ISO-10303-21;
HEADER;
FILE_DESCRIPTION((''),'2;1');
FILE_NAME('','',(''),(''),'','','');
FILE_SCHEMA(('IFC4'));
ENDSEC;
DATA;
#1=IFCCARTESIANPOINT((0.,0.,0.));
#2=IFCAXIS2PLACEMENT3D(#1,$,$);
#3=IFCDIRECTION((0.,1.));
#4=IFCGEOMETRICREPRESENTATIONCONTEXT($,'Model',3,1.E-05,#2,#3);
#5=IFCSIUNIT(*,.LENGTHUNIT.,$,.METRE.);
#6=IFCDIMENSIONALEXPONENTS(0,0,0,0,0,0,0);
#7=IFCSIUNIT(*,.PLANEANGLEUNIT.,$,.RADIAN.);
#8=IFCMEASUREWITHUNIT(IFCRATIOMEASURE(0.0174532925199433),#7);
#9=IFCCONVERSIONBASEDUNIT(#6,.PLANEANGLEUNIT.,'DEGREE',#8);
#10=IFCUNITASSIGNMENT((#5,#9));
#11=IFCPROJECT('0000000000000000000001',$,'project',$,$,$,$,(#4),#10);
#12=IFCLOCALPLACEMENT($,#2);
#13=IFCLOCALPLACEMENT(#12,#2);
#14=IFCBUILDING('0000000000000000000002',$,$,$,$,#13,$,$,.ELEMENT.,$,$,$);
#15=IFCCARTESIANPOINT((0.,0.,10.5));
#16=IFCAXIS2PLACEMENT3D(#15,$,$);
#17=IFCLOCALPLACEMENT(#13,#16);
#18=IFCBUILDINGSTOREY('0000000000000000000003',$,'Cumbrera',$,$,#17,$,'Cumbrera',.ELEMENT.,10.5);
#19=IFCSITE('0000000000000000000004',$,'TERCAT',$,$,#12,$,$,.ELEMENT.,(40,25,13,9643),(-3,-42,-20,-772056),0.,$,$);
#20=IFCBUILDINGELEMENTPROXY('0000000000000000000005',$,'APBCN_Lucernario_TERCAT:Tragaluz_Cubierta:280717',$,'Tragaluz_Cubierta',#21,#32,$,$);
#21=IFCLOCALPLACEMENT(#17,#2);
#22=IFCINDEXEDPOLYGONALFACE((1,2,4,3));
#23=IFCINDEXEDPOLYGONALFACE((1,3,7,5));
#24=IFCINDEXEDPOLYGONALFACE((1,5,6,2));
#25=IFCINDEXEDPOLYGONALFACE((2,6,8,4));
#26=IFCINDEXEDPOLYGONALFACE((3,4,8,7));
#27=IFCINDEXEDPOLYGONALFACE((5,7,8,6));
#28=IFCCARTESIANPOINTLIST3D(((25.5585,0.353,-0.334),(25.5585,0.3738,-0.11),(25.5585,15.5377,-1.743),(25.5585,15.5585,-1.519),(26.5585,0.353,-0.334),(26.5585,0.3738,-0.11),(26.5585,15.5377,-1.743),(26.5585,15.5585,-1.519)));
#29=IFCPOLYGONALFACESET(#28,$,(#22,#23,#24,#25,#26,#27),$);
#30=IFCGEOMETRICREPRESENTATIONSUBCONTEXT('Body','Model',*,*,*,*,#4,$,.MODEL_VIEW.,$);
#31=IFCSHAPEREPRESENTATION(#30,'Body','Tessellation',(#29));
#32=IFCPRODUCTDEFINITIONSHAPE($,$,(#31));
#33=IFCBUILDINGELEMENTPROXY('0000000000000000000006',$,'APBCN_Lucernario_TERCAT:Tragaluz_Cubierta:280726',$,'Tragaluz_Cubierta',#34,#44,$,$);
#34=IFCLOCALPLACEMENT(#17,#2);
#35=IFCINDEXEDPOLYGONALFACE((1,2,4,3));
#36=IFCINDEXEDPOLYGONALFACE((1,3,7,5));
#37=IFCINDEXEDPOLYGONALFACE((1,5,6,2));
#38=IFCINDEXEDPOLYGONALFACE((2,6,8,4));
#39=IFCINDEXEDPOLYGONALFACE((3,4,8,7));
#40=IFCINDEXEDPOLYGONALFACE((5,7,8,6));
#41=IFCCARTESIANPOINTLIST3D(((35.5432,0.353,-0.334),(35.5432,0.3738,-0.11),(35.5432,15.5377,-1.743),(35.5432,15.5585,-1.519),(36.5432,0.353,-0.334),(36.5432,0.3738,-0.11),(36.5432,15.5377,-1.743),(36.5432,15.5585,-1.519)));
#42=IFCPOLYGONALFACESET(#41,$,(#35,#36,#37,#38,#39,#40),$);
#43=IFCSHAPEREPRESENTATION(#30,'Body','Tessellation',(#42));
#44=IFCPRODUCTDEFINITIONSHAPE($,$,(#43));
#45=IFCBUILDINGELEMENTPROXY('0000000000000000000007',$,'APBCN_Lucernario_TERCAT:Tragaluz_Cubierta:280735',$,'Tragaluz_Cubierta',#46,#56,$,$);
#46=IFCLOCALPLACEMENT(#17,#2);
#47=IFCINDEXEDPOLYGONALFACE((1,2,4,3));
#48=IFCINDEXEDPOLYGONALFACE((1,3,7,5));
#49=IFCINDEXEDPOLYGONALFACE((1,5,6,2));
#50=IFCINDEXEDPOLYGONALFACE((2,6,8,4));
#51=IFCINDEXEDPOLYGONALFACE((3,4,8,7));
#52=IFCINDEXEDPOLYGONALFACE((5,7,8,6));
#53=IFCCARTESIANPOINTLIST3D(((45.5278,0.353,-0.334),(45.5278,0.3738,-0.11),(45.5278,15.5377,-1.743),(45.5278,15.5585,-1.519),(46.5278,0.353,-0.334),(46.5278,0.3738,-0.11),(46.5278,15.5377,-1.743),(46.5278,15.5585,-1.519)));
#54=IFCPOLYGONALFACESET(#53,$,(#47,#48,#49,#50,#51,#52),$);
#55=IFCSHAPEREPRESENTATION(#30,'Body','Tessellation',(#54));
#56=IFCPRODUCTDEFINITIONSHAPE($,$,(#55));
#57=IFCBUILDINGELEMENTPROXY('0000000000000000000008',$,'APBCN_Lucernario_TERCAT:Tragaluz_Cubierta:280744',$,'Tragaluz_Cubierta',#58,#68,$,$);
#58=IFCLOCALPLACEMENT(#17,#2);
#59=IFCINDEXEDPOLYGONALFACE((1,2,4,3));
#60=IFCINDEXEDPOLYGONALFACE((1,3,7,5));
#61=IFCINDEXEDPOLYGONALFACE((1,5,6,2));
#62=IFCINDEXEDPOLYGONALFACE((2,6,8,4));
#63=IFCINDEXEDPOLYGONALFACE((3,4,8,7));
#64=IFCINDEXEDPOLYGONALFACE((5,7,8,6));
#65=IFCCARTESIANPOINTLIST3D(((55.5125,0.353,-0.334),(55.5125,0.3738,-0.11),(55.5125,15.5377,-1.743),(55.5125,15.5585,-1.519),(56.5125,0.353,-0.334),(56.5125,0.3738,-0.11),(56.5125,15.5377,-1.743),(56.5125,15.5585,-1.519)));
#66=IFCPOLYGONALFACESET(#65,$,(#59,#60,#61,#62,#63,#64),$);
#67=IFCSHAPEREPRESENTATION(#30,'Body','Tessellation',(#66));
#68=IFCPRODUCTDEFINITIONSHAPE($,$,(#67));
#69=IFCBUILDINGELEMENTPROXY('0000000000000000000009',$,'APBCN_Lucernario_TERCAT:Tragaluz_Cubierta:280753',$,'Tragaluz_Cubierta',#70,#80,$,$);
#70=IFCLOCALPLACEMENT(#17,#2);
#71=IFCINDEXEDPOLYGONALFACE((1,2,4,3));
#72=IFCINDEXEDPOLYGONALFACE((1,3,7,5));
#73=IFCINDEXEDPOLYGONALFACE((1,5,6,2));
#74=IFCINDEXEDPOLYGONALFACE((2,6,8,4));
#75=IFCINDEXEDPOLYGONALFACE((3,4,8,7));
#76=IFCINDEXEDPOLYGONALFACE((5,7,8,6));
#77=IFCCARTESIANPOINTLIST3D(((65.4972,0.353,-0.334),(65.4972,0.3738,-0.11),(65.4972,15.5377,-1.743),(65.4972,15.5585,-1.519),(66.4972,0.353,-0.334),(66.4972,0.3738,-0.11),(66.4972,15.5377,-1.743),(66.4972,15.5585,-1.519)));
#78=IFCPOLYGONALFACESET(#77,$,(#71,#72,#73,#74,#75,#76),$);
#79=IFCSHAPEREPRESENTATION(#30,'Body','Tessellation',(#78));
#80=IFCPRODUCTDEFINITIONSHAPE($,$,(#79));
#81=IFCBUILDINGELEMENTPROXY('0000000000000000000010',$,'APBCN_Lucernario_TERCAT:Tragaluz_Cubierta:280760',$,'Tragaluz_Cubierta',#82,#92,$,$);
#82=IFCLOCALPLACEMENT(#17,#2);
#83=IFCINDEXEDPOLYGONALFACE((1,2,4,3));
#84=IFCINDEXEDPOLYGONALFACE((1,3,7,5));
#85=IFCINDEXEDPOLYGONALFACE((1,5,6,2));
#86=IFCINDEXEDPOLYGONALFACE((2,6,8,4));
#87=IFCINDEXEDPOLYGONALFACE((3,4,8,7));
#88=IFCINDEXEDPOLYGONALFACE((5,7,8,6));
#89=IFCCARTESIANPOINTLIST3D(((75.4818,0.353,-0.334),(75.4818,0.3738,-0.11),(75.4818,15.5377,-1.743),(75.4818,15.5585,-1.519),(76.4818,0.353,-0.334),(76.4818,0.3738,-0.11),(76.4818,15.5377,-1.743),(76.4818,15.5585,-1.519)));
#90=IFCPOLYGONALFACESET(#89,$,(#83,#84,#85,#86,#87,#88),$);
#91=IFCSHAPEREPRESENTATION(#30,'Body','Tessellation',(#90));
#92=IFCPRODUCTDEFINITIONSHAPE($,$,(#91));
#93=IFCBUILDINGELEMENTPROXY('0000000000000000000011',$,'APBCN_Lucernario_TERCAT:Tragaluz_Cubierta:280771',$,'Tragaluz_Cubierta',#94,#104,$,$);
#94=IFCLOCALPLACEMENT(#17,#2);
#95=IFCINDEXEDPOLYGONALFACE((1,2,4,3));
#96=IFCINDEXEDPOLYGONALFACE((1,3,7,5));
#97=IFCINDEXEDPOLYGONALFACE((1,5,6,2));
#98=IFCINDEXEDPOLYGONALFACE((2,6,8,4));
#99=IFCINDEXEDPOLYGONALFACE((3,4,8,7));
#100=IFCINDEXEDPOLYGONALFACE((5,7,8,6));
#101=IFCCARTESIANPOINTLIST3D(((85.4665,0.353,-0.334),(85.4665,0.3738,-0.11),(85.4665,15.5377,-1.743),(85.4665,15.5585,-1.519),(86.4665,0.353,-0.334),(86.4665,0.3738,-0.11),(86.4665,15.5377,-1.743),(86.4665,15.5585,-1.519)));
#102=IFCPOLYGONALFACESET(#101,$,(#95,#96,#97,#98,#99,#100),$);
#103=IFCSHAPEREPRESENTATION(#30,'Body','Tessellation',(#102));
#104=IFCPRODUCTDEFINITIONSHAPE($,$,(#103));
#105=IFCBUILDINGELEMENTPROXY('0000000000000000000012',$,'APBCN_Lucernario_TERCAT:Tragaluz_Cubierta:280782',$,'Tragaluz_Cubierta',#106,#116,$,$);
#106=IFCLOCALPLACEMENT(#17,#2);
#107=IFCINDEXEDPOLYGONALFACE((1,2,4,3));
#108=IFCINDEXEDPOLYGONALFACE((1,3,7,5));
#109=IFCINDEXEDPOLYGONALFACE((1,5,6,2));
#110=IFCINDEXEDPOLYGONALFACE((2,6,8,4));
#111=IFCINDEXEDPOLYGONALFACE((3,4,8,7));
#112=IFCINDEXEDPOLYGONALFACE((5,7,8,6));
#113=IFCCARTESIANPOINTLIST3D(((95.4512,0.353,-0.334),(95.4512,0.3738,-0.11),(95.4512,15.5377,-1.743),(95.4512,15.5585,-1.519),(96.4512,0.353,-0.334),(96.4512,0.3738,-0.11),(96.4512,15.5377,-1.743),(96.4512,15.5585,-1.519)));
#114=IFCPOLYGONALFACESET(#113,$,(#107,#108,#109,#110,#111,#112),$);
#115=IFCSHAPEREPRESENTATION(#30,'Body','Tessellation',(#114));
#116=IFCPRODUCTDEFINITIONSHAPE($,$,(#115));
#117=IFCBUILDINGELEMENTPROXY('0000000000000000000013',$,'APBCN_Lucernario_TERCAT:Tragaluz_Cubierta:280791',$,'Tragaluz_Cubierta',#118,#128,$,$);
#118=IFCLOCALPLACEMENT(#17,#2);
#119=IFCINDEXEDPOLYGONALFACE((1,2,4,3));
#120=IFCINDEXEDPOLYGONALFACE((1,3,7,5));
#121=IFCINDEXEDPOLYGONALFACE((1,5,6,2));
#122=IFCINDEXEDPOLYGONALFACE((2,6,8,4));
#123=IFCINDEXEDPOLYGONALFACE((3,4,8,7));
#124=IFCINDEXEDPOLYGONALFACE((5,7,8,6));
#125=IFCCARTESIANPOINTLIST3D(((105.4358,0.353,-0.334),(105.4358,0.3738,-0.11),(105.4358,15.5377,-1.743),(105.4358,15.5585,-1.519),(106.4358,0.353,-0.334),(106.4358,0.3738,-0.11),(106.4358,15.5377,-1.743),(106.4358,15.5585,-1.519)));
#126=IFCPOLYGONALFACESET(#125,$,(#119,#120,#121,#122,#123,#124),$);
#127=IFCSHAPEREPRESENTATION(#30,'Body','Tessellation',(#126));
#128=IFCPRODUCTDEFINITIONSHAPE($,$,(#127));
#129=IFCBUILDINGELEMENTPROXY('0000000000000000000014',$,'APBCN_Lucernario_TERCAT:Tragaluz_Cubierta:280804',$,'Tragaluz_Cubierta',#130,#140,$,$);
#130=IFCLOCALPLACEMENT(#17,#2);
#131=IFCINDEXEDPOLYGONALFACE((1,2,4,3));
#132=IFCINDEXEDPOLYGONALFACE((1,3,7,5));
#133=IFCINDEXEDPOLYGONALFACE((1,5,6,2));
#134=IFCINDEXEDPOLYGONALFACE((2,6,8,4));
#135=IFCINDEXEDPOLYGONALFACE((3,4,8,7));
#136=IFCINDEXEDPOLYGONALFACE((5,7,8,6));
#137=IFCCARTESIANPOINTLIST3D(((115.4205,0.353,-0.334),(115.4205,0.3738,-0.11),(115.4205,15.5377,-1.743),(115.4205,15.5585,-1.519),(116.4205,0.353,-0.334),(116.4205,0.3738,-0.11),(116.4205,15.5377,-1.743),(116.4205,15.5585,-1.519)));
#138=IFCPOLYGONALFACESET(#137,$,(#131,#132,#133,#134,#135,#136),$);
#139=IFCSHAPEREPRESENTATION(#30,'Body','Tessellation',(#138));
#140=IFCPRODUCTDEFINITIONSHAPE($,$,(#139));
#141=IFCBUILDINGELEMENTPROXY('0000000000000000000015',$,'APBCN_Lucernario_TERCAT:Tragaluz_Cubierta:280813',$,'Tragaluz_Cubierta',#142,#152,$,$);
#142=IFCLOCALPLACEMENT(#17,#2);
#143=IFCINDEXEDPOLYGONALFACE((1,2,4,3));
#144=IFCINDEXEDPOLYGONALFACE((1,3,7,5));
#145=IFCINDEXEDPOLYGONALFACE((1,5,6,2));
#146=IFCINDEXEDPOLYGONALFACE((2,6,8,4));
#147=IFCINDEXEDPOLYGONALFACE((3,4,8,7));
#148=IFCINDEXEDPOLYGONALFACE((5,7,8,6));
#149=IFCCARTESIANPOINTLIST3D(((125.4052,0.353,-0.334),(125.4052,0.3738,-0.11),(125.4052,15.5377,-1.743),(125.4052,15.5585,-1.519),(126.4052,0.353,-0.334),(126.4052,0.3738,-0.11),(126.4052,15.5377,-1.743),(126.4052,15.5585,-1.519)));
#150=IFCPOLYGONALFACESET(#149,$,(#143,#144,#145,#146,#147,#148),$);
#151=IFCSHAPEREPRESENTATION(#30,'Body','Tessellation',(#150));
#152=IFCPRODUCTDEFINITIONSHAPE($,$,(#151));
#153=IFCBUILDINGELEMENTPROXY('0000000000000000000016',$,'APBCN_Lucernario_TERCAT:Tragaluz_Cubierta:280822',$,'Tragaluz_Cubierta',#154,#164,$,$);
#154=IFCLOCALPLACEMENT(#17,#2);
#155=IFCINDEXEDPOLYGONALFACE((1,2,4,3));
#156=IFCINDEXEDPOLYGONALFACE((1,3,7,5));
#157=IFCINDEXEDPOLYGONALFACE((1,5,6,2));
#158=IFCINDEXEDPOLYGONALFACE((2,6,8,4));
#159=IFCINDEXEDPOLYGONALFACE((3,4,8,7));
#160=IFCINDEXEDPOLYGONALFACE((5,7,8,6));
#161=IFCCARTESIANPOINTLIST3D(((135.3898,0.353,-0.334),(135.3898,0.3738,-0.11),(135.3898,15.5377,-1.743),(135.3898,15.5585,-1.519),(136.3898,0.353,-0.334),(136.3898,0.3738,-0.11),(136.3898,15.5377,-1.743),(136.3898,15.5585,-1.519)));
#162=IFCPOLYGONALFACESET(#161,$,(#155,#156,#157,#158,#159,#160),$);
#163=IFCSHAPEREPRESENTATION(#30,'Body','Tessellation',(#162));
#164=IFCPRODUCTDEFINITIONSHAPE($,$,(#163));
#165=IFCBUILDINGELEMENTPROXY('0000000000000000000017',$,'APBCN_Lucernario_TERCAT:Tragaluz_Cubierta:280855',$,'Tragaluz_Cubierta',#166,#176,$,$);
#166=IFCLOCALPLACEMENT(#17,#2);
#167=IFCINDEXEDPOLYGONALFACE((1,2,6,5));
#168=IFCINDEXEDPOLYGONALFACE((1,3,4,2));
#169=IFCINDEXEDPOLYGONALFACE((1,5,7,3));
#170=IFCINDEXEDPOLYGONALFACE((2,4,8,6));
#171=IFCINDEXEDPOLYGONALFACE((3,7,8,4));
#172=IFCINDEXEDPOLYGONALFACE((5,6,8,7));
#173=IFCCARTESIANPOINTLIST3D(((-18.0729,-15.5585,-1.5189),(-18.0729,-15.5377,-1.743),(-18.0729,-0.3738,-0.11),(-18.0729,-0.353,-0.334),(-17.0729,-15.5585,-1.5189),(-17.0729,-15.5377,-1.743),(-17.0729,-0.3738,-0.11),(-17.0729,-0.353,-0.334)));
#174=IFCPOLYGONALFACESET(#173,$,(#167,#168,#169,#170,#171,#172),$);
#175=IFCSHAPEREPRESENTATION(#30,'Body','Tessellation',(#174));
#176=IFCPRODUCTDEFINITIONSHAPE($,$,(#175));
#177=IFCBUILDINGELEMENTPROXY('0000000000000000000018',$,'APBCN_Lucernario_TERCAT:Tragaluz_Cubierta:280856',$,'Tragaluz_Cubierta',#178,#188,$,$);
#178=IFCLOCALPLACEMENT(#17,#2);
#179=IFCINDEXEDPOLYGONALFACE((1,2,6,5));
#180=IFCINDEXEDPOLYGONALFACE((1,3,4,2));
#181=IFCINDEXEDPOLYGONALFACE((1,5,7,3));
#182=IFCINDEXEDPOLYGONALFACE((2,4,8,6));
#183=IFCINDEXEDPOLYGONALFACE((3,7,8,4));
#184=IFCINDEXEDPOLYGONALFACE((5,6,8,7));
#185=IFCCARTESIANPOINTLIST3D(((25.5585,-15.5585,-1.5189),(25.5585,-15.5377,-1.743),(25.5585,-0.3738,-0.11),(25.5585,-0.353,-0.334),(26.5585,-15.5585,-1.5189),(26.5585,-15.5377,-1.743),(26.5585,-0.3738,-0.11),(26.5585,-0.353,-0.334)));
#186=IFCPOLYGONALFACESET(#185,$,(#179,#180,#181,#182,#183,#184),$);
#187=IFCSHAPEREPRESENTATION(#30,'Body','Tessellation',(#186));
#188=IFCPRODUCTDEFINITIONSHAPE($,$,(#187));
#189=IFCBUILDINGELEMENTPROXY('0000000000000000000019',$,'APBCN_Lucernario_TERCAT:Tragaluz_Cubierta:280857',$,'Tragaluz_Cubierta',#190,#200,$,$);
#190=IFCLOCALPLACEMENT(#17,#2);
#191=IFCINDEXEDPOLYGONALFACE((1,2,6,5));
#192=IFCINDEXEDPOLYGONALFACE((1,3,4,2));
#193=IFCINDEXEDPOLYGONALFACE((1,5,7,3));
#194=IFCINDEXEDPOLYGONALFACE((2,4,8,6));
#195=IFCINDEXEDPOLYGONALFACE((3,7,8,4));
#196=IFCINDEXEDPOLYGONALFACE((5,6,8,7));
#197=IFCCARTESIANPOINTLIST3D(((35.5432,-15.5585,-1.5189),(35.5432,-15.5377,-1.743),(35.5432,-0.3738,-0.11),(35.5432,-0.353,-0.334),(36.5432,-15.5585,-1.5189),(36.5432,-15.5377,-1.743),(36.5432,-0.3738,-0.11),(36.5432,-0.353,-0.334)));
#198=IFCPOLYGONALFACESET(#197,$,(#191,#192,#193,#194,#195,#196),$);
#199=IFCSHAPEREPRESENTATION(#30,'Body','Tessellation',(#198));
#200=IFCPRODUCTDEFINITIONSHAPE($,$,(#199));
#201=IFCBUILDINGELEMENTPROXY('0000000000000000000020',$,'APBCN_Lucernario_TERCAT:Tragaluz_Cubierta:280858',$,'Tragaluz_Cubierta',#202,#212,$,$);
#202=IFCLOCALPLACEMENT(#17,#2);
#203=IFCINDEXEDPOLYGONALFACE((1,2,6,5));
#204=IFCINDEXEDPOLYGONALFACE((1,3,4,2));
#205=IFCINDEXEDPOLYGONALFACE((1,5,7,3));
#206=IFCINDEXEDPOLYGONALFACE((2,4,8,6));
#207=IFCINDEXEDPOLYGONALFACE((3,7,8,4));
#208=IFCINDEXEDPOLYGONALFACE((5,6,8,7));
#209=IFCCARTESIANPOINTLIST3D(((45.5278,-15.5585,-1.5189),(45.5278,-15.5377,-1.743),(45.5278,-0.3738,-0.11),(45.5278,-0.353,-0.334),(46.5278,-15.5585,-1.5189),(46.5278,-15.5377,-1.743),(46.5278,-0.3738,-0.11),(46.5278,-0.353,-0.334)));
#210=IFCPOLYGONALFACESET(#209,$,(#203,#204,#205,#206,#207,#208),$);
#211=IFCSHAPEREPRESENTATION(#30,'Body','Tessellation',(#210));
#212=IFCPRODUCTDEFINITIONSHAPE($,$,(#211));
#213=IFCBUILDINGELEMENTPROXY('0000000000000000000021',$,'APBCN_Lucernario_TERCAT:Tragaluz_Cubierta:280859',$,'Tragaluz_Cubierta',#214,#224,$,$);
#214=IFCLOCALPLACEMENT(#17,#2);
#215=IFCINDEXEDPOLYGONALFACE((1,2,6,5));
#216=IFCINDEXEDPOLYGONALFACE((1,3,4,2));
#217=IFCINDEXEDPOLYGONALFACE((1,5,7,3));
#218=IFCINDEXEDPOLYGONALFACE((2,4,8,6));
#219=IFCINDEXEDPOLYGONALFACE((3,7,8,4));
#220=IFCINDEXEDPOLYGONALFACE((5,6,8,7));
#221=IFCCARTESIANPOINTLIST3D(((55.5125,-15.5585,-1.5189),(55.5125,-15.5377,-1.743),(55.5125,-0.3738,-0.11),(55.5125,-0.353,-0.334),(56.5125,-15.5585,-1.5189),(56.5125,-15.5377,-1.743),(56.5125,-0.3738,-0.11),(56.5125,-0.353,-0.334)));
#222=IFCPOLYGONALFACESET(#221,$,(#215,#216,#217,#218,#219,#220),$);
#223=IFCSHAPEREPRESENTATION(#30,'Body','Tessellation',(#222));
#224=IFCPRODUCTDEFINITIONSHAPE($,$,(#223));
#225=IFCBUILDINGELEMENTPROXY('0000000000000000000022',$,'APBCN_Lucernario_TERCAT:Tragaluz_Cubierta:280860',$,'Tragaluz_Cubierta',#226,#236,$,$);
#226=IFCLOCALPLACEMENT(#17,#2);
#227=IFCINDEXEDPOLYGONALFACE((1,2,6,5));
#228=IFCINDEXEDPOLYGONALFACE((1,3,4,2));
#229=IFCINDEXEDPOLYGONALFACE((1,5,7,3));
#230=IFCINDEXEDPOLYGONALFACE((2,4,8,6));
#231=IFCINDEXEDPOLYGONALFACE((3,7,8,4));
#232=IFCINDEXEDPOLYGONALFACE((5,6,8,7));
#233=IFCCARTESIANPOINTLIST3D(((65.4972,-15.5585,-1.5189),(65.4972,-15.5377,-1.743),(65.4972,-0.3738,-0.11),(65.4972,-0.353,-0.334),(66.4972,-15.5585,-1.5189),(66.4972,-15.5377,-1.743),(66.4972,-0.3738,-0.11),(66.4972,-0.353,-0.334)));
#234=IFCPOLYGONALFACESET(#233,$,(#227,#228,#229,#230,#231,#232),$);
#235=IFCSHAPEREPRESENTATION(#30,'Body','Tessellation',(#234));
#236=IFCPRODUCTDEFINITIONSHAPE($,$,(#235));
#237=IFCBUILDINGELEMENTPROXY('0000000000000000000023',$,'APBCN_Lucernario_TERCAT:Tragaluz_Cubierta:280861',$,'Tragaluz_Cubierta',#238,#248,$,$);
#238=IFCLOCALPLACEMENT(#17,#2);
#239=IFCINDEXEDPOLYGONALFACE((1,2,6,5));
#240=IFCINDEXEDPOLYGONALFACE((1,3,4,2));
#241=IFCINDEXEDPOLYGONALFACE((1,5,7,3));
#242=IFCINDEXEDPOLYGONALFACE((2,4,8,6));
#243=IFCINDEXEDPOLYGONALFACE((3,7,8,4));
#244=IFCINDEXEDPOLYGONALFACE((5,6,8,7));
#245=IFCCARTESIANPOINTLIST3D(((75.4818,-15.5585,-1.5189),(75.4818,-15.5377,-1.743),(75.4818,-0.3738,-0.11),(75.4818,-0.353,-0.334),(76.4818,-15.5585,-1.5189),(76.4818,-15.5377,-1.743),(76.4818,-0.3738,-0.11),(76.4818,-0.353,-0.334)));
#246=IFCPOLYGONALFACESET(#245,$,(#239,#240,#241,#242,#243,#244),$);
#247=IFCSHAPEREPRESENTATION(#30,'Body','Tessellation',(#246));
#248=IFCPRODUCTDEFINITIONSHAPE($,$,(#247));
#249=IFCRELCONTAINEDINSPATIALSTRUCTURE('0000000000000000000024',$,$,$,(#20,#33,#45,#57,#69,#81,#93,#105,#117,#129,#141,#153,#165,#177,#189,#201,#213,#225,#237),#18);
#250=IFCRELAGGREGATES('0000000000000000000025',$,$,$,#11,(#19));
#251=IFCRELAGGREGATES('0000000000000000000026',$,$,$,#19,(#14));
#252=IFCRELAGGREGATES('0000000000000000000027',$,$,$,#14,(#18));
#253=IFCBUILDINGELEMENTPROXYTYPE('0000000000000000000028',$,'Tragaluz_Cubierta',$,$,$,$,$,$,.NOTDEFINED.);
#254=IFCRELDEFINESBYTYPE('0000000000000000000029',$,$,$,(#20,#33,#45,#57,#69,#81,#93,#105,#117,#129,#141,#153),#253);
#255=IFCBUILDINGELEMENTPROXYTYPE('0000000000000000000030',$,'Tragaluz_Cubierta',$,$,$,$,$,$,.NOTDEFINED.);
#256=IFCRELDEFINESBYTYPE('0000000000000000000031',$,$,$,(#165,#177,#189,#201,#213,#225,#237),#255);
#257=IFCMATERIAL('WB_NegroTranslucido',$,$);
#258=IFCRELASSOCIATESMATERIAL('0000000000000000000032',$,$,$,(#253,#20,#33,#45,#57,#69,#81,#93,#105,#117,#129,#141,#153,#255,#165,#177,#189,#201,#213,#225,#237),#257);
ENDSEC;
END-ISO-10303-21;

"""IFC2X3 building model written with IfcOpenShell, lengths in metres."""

from ifc_helpers import new_model, entity, si_unit, converted_unit, direction, frame, origin, origin_2d_with_axis, place, context, subcontext, project, spatial, rectangle, extrude, source, transform, mapped, material, type_object, type_shapes, element, save


model = new_model("IFC2X3")

# Units and contexts
model_context = context("Model", 3, precision=1e-05, world=origin(), true_north=direction((0.0, 1.0)))
body_context = subcontext(model_context, "Body", "Model", "MODEL_VIEW")
ifc_project = project(units=[si_unit("LENGTHUNIT", "METRE"), converted_unit("PLANEANGLEUNIT", "DEGREE", entity("IfcRatioMeasure", 0.0174532925199433), si_unit("PLANEANGLEUNIT", "RADIAN"), dimensions=[0, 0, 0, 0, 0, 0, 0])], contexts=[model_context])

# Site, building, storey
site_placement = place(None, origin())
site = spatial("IfcSite", under=ifc_project, at=site_placement, Name="TERCAT", CompositionType="ELEMENT", RefLatitude=(40, 25, 13, 9643), RefLongitude=(-3, -42, -20, -772056), RefElevation=0.0)
building_placement = place(site_placement, origin())
building = spatial("IfcBuilding", under=site, at=building_placement, CompositionType="ELEMENT")
storey_placement = place(building_placement, frame((0.0, 0.0, 10.5)))
storey = spatial("IfcBuildingStorey", under=building, at=storey_placement, Name="Cumbrera", LongName="Cumbrera", CompositionType="ELEMENT", Elevation=10.5)

# Building element proxies
ifc_material_1 = material(Name="WB_NegroTranslucido")
building_element_proxy_type_1 = type_object("IfcBuildingElementProxyType", Name="Tragaluz_Cubierta", PredefinedType="NOTDEFINED", material=ifc_material_1)
shared_shape_1 = source(origin(), body_context, "Body", "SweptSolid", [
    extrude(rectangle(XDim=1.0, YDim=15.25, at=origin_2d_with_axis()), frame((0.5, 7.625, 0.0), z_axis=(0.0, 0.0, 1.0), x_axis=(-1.0, 0.0, 0.0)), (0.0, 0.0, 1.0), 0.225),
])
type_shapes(building_element_proxy_type_1, [shared_shape_1])
for number, where, z_axis, x_axis, name in (
    (1, (26.5585, 15.5377, -1.743), (0.0, 0.092394, 0.995723), (-1.0, 0.0, 0.0), "APBCN_Lucernario_TERCAT:Tragaluz_Cubierta:280717"),
    (2, (36.5432, 15.5377, -1.743), (0.0, 0.092394, 0.995723), (-1.0, 0.0, 0.0), "APBCN_Lucernario_TERCAT:Tragaluz_Cubierta:280726"),
    (3, (46.5278, 15.5377, -1.743), (0.0, 0.092394, 0.995723), (-1.0, 0.0, 0.0), "APBCN_Lucernario_TERCAT:Tragaluz_Cubierta:280735"),
    (4, (56.5125, 15.5377, -1.743), (0.0, 0.092394, 0.995723), (-1.0, 0.0, 0.0), "APBCN_Lucernario_TERCAT:Tragaluz_Cubierta:280744"),
    (5, (66.4972, 15.5377, -1.743), (0.0, 0.092394, 0.995723), (-1.0, 0.0, 0.0), "APBCN_Lucernario_TERCAT:Tragaluz_Cubierta:280753"),
    (6, (76.4818, 15.5377, -1.743), (0.0, 0.092394, 0.995723), (-1.0, 0.0, 0.0), "APBCN_Lucernario_TERCAT:Tragaluz_Cubierta:280760"),
    (7, (86.4665, 15.5377, -1.743), (0.0, 0.092394, 0.995723), (-1.0, 0.0, 0.0), "APBCN_Lucernario_TERCAT:Tragaluz_Cubierta:280771"),
    (8, (96.4512, 15.5377, -1.743), (0.0, 0.092394, 0.995723), (-1.0, 0.0, 0.0), "APBCN_Lucernario_TERCAT:Tragaluz_Cubierta:280782"),
    (9, (106.4358, 15.5377, -1.743), (0.0, 0.092394, 0.995723), (-1.0, 0.0, 0.0), "APBCN_Lucernario_TERCAT:Tragaluz_Cubierta:280791"),
    (10, (116.4205, 15.5377, -1.743), (0.0, 0.092394, 0.995723), (-1.0, 0.0, 0.0), "APBCN_Lucernario_TERCAT:Tragaluz_Cubierta:280804"),
    (11, (126.4052, 15.5377, -1.743), (0.0, 0.092394, 0.995723), (-1.0, 0.0, 0.0), "APBCN_Lucernario_TERCAT:Tragaluz_Cubierta:280813"),
    (12, (136.3898, 15.5377, -1.743), (0.0, 0.092394, 0.995723), (-1.0, 0.0, 0.0), "APBCN_Lucernario_TERCAT:Tragaluz_Cubierta:280822"),
):
    element("IfcBuildingElementProxy", number, at=place(storey_placement, frame(where, z_axis=z_axis, x_axis=x_axis)), inside=storey, type_object=building_element_proxy_type_1, material=ifc_material_1, Name=name, ObjectType="Tragaluz_Cubierta", context=body_context, shape_type="MappedRepresentation", body=[
        mapped(shared_shape_1, transform((0.0, 0.0, 0.0), scale=1.0)),
    ])
building_element_proxy_type_2 = type_object("IfcBuildingElementProxyType", Name="Tragaluz_Cubierta", PredefinedType="NOTDEFINED", material=ifc_material_1)
shared_shape_2 = source(origin(), body_context, "Body", "SweptSolid", [
    extrude(rectangle(XDim=15.25, YDim=1.0, at=origin_2d_with_axis()), frame((0.5, 7.625, 0.0), z_axis=(0.0, 0.0, 1.0), x_axis=(0.0, 1.0, 0.0)), (0.0, 0.0, 1.0), 0.225),
])
type_shapes(building_element_proxy_type_2, [shared_shape_2])
for number, where, z_axis, x_axis, name in (
    (13, (-17.0729, -0.353, -0.334), (0.0, -0.09239, 0.995723), (-1.0, 0.0, 0.0), "APBCN_Lucernario_TERCAT:Tragaluz_Cubierta:280855"),
    (14, (26.5585, -0.353, -0.334), (0.0, -0.09239, 0.995723), (-1.0, 0.0, 0.0), "APBCN_Lucernario_TERCAT:Tragaluz_Cubierta:280856"),
    (15, (36.5432, -0.353, -0.334), (0.0, -0.09239, 0.995723), (-1.0, 0.0, 0.0), "APBCN_Lucernario_TERCAT:Tragaluz_Cubierta:280857"),
    (16, (46.5278, -0.353, -0.334), (0.0, -0.09239, 0.995723), (-1.0, 0.0, 0.0), "APBCN_Lucernario_TERCAT:Tragaluz_Cubierta:280858"),
    (17, (56.5125, -0.353, -0.334), (0.0, -0.09239, 0.995723), (-1.0, 0.0, 0.0), "APBCN_Lucernario_TERCAT:Tragaluz_Cubierta:280859"),
    (18, (66.4972, -0.353, -0.334), (0.0, -0.09239, 0.995723), (-1.0, 0.0, 0.0), "APBCN_Lucernario_TERCAT:Tragaluz_Cubierta:280860"),
    (19, (76.4818, -0.353, -0.334), (0.0, -0.09239, 0.995723), (-1.0, 0.0, 0.0), "APBCN_Lucernario_TERCAT:Tragaluz_Cubierta:280861"),
):
    element("IfcBuildingElementProxy", number, at=place(storey_placement, frame(where, z_axis=z_axis, x_axis=x_axis)), inside=storey, type_object=building_element_proxy_type_2, material=ifc_material_1, Name=name, ObjectType="Tragaluz_Cubierta", context=body_context, shape_type="MappedRepresentation", body=[
        mapped(shared_shape_2, transform((0.0, 0.0, 0.0), scale=1.0)),
    ])

save(model, "model.ifc")
